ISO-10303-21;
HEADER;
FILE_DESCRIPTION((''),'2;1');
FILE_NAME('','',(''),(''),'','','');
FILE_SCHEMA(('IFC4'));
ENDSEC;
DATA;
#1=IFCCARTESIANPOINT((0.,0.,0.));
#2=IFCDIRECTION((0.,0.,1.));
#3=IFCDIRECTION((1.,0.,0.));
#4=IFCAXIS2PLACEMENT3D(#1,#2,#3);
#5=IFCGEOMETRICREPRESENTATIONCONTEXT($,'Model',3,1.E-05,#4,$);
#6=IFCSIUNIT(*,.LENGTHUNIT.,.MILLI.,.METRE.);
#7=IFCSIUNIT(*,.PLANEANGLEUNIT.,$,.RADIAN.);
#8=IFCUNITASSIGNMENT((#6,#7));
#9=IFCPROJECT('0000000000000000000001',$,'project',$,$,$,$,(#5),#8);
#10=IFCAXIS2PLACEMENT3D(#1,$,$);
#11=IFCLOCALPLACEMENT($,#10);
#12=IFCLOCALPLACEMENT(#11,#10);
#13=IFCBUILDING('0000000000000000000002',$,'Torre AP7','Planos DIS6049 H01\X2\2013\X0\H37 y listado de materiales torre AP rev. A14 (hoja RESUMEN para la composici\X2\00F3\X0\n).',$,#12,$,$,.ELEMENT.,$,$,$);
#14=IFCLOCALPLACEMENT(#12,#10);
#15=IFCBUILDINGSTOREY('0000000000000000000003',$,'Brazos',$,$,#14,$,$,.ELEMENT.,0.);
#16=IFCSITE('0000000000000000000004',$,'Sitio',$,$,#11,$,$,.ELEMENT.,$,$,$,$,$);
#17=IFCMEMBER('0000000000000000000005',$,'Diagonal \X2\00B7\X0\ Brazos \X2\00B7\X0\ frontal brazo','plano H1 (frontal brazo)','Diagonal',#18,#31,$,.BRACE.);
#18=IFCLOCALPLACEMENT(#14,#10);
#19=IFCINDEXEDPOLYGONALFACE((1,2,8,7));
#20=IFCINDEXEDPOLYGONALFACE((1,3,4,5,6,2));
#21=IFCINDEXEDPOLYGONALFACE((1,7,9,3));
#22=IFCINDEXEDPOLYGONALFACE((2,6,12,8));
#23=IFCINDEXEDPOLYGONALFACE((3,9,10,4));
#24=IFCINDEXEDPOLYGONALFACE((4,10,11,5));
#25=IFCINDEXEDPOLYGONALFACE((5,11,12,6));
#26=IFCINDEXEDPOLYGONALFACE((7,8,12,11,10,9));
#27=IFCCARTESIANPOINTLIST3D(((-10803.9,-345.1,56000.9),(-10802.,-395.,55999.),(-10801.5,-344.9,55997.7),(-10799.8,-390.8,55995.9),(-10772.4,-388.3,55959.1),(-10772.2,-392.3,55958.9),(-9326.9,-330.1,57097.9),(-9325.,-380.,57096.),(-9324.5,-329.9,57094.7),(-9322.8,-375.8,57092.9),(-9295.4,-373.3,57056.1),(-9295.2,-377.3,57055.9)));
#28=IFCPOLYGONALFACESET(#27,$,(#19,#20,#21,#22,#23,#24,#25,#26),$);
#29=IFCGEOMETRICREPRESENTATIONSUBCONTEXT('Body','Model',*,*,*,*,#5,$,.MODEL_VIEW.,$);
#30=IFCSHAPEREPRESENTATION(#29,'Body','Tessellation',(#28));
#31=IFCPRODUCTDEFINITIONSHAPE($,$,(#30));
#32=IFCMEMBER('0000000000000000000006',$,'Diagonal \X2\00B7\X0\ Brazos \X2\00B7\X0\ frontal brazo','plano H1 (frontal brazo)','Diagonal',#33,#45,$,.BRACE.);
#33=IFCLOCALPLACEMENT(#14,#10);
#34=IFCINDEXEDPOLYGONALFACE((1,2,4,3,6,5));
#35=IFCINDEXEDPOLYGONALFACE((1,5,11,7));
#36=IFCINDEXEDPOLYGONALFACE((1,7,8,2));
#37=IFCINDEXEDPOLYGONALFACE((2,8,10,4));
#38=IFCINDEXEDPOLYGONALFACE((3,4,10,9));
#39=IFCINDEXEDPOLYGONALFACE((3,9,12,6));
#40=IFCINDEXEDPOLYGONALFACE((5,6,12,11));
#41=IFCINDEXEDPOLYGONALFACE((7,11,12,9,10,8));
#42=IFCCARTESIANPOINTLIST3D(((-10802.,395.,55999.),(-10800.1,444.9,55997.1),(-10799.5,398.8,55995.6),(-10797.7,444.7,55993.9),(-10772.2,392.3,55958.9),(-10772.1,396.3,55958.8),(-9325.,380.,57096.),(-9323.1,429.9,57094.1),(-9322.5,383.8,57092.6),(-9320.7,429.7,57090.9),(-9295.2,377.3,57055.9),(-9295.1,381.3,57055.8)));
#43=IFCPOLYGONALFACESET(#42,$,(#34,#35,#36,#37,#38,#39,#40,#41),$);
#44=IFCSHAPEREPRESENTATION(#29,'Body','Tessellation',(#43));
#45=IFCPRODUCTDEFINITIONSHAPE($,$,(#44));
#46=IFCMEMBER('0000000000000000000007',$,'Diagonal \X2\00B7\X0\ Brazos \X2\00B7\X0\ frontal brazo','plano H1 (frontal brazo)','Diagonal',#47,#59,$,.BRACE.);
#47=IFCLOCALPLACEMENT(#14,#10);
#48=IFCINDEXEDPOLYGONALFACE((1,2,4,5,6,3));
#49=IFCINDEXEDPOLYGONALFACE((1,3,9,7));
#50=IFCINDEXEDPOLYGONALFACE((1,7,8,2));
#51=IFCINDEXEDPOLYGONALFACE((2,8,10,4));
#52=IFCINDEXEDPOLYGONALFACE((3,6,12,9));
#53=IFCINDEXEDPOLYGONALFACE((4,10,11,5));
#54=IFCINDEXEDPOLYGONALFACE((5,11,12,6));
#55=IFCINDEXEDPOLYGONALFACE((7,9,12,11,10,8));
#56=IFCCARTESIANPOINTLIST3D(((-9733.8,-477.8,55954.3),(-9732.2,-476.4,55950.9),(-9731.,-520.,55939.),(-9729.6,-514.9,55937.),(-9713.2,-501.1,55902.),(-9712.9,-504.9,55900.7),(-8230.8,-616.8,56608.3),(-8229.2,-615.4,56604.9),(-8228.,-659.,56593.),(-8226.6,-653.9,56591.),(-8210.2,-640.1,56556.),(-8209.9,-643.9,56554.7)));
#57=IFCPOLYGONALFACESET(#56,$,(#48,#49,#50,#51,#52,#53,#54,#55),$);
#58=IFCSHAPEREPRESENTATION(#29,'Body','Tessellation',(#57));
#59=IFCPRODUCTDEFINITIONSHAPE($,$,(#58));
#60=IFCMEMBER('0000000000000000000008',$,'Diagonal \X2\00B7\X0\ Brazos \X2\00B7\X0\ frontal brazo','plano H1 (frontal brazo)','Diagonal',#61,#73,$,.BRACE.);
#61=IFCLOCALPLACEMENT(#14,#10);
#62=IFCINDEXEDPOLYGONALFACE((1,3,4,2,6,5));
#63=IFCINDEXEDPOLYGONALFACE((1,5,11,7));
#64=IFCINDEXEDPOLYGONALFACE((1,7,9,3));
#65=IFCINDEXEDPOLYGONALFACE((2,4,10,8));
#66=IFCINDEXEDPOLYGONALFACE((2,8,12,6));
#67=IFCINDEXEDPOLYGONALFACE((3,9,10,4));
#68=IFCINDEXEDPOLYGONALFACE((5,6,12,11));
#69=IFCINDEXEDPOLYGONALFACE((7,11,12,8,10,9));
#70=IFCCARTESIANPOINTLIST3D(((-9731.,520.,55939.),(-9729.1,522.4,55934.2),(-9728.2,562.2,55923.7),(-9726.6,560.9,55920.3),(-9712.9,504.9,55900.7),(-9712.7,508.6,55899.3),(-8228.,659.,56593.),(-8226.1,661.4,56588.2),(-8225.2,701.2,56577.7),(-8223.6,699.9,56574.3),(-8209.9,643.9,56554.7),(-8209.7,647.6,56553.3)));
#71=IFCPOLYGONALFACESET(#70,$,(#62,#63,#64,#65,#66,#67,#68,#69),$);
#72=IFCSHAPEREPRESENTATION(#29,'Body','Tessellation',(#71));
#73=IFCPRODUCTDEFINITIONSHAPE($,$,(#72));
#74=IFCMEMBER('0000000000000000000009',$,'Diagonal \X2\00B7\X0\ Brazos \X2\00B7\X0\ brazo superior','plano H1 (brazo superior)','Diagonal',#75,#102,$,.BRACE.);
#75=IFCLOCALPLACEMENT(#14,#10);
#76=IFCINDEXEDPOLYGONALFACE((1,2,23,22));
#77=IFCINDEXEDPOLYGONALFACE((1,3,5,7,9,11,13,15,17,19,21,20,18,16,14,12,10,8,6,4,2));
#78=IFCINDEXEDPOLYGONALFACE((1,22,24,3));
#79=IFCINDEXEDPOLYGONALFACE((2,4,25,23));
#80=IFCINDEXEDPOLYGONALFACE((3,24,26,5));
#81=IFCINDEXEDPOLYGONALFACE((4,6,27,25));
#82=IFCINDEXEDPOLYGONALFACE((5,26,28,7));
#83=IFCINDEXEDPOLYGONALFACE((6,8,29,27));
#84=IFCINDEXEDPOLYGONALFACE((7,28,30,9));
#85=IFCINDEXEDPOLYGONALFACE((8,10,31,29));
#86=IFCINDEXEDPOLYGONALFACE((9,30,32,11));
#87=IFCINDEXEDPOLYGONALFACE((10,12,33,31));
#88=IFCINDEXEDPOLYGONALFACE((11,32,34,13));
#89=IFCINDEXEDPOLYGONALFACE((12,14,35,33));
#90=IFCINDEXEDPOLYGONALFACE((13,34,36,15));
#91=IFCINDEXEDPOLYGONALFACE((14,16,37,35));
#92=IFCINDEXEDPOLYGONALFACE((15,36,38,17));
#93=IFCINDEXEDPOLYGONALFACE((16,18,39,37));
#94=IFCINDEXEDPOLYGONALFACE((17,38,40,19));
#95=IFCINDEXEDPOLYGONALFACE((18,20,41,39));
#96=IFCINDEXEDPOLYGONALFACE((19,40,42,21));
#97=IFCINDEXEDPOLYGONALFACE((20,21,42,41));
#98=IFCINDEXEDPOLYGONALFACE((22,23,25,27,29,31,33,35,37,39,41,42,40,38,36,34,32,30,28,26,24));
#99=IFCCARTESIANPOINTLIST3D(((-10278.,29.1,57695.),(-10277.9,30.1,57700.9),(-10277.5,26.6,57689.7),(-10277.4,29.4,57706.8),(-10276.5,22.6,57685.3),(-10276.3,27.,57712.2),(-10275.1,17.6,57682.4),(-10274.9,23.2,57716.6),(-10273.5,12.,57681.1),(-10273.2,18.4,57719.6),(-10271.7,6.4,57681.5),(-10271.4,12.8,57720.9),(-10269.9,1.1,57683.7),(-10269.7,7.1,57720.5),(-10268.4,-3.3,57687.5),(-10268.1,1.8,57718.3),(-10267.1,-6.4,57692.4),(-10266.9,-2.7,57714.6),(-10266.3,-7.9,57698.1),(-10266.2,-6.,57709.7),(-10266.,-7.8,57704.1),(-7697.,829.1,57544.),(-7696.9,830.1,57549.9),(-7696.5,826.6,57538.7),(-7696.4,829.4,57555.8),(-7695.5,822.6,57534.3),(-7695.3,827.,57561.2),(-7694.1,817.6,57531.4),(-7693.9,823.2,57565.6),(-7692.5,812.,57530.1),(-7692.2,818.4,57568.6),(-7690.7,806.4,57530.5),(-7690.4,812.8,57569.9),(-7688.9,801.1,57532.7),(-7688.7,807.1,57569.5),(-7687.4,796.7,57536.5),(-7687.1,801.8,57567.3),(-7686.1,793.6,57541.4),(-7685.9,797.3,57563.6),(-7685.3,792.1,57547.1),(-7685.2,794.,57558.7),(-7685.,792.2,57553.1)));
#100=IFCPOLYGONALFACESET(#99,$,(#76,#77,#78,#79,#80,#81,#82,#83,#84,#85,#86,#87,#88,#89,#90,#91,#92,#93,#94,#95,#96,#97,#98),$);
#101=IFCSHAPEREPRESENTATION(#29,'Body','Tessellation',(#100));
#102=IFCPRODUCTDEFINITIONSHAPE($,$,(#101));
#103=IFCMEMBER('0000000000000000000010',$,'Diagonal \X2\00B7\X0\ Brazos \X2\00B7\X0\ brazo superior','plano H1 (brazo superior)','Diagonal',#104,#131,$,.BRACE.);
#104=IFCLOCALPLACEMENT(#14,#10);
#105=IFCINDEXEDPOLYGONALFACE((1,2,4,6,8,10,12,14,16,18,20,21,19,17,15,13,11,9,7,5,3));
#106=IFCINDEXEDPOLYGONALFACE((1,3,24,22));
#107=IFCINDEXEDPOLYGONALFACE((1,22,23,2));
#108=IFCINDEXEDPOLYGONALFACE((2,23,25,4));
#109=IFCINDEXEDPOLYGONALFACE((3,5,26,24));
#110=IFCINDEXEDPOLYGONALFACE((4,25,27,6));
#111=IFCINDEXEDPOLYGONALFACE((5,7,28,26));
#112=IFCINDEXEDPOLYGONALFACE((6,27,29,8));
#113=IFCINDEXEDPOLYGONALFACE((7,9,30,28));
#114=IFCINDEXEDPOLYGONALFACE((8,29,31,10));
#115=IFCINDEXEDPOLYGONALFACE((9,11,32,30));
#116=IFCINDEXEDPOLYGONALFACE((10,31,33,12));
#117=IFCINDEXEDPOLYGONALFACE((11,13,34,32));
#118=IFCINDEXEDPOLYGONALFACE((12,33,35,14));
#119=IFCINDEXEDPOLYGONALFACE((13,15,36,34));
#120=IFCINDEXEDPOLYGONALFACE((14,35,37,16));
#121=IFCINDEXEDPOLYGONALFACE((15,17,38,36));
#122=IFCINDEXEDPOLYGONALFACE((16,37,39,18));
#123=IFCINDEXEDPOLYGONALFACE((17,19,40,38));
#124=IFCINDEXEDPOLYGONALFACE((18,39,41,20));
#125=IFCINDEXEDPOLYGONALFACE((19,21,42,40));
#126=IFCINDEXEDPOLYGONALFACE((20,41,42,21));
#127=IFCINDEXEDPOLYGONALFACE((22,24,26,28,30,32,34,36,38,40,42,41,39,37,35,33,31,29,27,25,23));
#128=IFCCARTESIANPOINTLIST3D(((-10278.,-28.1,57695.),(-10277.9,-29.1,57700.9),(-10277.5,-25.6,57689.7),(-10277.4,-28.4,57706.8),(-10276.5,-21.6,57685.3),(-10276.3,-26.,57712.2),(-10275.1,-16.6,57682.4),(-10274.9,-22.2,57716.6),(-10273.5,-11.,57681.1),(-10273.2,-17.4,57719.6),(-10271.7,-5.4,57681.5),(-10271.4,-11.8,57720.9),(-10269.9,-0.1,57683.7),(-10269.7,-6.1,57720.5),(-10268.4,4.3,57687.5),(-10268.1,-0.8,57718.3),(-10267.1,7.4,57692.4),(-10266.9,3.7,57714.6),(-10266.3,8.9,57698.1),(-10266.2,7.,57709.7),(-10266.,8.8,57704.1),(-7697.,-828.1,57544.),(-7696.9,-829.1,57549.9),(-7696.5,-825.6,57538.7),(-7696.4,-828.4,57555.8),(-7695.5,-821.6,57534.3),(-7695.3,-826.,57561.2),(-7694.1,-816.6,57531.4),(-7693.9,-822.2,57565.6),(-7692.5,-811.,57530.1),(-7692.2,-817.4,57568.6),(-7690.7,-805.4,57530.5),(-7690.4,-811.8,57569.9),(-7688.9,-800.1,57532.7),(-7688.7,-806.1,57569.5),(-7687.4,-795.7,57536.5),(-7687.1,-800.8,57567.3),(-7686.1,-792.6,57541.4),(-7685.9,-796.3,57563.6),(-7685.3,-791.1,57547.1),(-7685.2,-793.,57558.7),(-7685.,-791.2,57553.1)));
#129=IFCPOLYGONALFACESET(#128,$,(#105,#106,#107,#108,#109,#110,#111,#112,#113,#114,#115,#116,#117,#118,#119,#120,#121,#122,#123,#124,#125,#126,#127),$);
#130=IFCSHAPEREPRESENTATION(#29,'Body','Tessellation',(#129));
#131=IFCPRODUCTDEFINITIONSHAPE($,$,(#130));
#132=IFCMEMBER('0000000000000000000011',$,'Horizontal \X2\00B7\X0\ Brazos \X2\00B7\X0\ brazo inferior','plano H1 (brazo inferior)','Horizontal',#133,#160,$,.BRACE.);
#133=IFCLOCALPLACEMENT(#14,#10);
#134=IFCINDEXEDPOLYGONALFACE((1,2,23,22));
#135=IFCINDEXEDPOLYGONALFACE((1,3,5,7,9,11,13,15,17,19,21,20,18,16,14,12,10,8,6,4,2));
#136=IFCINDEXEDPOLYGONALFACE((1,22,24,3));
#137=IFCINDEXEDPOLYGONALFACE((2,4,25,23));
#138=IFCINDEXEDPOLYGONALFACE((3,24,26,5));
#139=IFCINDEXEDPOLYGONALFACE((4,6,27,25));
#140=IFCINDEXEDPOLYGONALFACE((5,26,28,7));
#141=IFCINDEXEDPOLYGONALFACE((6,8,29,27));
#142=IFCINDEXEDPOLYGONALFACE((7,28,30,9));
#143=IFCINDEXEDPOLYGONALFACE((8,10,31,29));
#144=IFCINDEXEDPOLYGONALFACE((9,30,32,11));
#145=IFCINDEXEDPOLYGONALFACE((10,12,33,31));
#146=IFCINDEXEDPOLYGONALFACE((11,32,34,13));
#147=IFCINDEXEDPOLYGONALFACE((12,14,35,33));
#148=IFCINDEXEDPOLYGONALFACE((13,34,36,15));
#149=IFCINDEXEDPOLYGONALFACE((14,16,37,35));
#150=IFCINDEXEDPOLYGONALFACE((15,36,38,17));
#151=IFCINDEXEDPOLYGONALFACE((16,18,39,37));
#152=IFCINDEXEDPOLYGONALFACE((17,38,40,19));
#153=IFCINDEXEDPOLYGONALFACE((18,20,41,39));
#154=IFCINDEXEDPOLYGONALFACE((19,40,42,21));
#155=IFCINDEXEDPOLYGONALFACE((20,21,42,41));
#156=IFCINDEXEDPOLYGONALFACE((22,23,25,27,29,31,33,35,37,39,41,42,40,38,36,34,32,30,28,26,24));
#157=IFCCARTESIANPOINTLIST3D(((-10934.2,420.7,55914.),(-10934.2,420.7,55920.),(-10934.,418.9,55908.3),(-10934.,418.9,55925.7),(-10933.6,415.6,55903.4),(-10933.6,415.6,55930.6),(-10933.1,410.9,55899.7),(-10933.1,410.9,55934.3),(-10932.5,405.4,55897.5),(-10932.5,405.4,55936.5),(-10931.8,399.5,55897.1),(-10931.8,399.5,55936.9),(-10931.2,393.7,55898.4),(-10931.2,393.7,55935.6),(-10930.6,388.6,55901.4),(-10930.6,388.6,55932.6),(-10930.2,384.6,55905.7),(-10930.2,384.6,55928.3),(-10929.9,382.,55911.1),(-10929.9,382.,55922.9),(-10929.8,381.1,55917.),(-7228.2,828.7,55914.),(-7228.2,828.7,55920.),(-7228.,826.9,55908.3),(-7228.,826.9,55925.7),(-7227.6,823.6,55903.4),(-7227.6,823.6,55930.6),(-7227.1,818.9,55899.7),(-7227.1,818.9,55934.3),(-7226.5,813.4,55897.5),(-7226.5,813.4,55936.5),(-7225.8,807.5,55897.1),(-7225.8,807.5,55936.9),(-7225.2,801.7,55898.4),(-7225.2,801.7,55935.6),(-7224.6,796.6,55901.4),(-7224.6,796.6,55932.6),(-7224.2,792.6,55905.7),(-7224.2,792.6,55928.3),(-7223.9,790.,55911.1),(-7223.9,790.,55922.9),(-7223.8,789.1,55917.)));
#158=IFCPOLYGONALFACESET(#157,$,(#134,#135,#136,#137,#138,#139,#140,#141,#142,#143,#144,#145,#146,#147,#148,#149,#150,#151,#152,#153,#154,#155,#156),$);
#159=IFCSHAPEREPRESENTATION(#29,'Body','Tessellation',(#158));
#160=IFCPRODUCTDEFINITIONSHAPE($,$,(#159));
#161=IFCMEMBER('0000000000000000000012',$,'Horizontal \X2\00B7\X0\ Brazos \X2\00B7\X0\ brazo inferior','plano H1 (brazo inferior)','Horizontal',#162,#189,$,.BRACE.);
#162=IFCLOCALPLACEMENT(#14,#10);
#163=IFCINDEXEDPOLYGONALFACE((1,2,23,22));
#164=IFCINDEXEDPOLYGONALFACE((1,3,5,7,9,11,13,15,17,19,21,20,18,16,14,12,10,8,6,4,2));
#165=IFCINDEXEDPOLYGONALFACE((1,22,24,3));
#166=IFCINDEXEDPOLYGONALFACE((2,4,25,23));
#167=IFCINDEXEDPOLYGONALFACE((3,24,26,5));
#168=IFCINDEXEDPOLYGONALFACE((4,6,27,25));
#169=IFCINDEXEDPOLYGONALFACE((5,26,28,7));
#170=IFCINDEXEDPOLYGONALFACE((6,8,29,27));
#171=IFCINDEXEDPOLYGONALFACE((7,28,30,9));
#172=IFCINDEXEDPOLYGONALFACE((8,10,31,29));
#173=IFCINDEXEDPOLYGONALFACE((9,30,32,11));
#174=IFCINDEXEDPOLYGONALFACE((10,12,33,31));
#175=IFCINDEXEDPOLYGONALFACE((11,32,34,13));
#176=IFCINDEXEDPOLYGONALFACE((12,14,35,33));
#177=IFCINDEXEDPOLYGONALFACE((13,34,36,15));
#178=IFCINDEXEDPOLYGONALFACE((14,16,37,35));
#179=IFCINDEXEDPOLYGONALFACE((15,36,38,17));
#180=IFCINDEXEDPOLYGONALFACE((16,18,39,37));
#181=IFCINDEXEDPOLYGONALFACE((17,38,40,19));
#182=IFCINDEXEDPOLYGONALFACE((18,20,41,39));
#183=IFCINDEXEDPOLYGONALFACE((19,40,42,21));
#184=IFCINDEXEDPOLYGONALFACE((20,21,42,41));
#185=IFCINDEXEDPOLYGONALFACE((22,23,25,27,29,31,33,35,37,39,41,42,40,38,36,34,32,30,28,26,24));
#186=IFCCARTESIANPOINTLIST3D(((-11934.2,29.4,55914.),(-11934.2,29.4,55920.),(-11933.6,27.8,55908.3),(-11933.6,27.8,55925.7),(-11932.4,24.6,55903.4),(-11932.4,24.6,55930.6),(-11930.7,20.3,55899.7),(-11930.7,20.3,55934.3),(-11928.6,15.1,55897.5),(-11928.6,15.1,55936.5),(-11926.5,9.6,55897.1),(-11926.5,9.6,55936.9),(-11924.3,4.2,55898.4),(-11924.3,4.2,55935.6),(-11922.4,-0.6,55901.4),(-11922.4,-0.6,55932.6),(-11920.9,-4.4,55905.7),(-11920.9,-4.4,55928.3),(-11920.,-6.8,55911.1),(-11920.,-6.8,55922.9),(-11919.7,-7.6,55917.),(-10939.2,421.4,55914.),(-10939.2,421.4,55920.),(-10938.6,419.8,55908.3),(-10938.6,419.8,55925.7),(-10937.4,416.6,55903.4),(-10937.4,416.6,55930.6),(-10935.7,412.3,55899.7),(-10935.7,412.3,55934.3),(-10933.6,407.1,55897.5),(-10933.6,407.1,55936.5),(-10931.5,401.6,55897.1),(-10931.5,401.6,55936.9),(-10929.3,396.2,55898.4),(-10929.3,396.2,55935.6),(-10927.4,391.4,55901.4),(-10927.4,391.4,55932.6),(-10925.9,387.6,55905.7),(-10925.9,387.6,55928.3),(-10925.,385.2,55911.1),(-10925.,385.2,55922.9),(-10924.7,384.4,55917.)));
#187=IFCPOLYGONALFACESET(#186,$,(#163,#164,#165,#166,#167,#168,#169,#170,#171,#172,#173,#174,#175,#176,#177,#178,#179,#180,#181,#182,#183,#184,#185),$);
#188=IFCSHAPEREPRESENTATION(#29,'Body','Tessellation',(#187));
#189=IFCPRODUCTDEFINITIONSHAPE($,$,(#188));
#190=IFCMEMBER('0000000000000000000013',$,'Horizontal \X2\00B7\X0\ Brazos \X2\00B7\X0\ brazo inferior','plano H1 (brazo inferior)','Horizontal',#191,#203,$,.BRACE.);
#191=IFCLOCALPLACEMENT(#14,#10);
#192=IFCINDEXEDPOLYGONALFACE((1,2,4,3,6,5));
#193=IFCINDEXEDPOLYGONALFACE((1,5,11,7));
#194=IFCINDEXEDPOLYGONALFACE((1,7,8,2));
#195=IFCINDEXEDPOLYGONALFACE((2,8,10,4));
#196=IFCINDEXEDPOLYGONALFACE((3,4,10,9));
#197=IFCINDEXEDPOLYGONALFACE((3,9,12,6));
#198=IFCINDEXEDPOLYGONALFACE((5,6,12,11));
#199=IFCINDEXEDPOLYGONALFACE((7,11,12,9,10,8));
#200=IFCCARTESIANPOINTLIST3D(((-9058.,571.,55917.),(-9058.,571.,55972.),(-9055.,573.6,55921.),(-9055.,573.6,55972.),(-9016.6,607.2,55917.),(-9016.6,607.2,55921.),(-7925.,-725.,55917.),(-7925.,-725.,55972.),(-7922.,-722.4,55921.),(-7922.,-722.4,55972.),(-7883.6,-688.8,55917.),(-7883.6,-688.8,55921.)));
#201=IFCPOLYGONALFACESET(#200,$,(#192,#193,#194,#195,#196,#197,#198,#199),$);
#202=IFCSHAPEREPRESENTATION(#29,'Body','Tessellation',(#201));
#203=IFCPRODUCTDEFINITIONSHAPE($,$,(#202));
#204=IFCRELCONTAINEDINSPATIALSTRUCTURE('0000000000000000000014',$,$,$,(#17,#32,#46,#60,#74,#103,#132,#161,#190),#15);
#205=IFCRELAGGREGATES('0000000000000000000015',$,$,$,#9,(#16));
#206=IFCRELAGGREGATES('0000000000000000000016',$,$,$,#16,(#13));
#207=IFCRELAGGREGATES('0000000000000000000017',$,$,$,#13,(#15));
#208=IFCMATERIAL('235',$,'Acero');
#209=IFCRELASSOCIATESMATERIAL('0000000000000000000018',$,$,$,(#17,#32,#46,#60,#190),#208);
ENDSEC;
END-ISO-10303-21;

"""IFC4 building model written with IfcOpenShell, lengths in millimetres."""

from ifc_helpers import new_model, si_unit, frame, frame_2d, origin, origin_with_axes, place, context, subcontext, project, spatial, circle, l_section, extrude, material, element, save


model = new_model("IFC4")

# Units and contexts
model_context = context("Model", 3, precision=1e-05, world=origin_with_axes())
body_context = subcontext(model_context, "Body", "Model", "MODEL_VIEW")
ifc_project = project(units=[si_unit("LENGTHUNIT", "METRE", prefix="MILLI"), si_unit("PLANEANGLEUNIT", "RADIAN")], contexts=[model_context])

# Site, building, storey
site_placement = place(None, origin())
site = spatial("IfcSite", under=ifc_project, at=site_placement, Name="Sitio", CompositionType="ELEMENT")
building_placement = place(site_placement, origin())
building = spatial("IfcBuilding", under=site, at=building_placement, Name="Torre AP7", Description="Planos DIS6049 H01–H37 y listado de materiales torre AP rev. A14 (hoja RESUMEN para la composición).", CompositionType="ELEMENT")
storey_placement = place(building_placement, origin())
storey = spatial("IfcBuildingStorey", under=building, at=storey_placement, Name="Brazos", CompositionType="ELEMENT", Elevation=0.0)

# Members
ifc_material_1 = material(Name="235", Category="Acero")
for number, where, z_axis, x_axis, name in (
    (1, (-10802.0, -395.0, 55999.0), (0.802769, 0.008153, 0.596234), (0.595049, 0.053521, -0.801905), "Diagonal · Brazos · frontal brazo"),
    (2, (-10802.0, 395.0, 55999.0), (0.802769, -0.008153, 0.596234), (0.595049, -0.053521, -0.801905), "Diagonal · Brazos · frontal brazo"),
):
    element("IfcMember", number, at=place(storey_placement, frame(where, z_axis=z_axis, x_axis=x_axis)), inside=storey, material=ifc_material_1, Name=name, Description="plano H1 (frontal brazo)", ObjectType="Diagonal", PredefinedType="BRACE", context=body_context, shape_type="SweptSolid", body=[
        extrude(l_section(Depth=50.0, Width=50.0, Thickness=4.0, at=frame_2d((25.0, 25.0))), None, (0.0, 0.0, 1.0), 1839.9),
    ])
for number, where, z_axis, x_axis, name in (
    (3, (-9731.0, -520.0, 55939.0), (0.913674, -0.084498, 0.397567), (0.401755, 0.335963, -0.851893), "Diagonal · Brazos · frontal brazo"),
    (4, (-9731.0, 520.0, 55939.0), (0.913674, 0.084498, 0.397567), (0.401755, -0.335963, -0.851893), "Diagonal · Brazos · frontal brazo"),
):
    element("IfcMember", number, at=place(storey_placement, frame(where, z_axis=z_axis, x_axis=x_axis)), inside=storey, material=ifc_material_1, Name=name, Description="plano H1 (frontal brazo)", ObjectType="Diagonal", PredefinedType="BRACE", context=body_context, shape_type="SweptSolid", body=[
        extrude(l_section(Depth=45.0, Width=45.0, Thickness=4.0, at=frame_2d((22.5, 22.5))), None, (0.0, 0.0, 1.0), 1645.0),
    ])
for number, where, z_axis, x_axis, name in (
    (5, (-7691.0, 811.0, 57550.0), (-0.953681, -0.2956, 0.055795), (0.300728, -0.941427, 0.152572), "Diagonal · Brazos · brazo superior"),
    (6, (-10272.0, -10.0, 57701.0), (0.953681, -0.2956, -0.055795), (0.300729, 0.941418, 0.152624), "Diagonal · Brazos · brazo superior"),
):
    element("IfcMember", number, at=place(storey_placement, frame(where, z_axis=z_axis, x_axis=x_axis)), inside=storey, Name=name, Description="plano H1 (brazo superior)", ObjectType="Diagonal", PredefinedType="BRACE", context=body_context, shape_type="SweptSolid", body=[
        extrude(circle(Radius=20.0), None, (0.0, 0.0, 1.0), 2706.4),
    ])
member_1_placement = place(storey_placement, frame((-7226.0, 809.0, 55917.0), z_axis=(-0.993994, -0.109431, 0.0), x_axis=(0.109431, -0.993994, 0.0)))
element("IfcMember", 7, at=member_1_placement, inside=storey, Name="Horizontal · Brazos · brazo inferior", Description="plano H1 (brazo inferior)", ObjectType="Horizontal", PredefinedType="BRACE", context=body_context, shape_type="SweptSolid", body=[
    extrude(circle(Radius=20.0), None, (0.0, 0.0, 1.0), 3728.4),
])
member_2_placement = place(storey_placement, frame((-10932.0, 403.0, 55917.0), z_axis=(-0.930399, -0.366549, 0.0), x_axis=(0.366549, -0.930399, 0.0)))
element("IfcMember", 8, at=member_2_placement, inside=storey, Name="Horizontal · Brazos · brazo inferior", Description="plano H1 (brazo inferior)", ObjectType="Horizontal", PredefinedType="BRACE", context=body_context, shape_type="SweptSolid", body=[
    extrude(circle(Radius=20.0), None, (0.0, 0.0, 1.0), 1069.4),
])
member_3_placement = place(storey_placement, frame((-9058.0, 571.0, 55917.0), z_axis=(0.658176, -0.752865, 0.0), x_axis=(0.752865, 0.658176, 0.0)))
element("IfcMember", 9, at=member_3_placement, inside=storey, material=ifc_material_1, Name="Horizontal · Brazos · brazo inferior", Description="plano H1 (brazo inferior)", ObjectType="Horizontal", PredefinedType="BRACE", context=body_context, shape_type="SweptSolid", body=[
    extrude(l_section(Depth=55.0, Width=55.0, Thickness=4.0, at=frame_2d((27.5, 27.5))), None, (0.0, 0.0, 1.0), 1721.4),
])

save(model, "model.ifc")
